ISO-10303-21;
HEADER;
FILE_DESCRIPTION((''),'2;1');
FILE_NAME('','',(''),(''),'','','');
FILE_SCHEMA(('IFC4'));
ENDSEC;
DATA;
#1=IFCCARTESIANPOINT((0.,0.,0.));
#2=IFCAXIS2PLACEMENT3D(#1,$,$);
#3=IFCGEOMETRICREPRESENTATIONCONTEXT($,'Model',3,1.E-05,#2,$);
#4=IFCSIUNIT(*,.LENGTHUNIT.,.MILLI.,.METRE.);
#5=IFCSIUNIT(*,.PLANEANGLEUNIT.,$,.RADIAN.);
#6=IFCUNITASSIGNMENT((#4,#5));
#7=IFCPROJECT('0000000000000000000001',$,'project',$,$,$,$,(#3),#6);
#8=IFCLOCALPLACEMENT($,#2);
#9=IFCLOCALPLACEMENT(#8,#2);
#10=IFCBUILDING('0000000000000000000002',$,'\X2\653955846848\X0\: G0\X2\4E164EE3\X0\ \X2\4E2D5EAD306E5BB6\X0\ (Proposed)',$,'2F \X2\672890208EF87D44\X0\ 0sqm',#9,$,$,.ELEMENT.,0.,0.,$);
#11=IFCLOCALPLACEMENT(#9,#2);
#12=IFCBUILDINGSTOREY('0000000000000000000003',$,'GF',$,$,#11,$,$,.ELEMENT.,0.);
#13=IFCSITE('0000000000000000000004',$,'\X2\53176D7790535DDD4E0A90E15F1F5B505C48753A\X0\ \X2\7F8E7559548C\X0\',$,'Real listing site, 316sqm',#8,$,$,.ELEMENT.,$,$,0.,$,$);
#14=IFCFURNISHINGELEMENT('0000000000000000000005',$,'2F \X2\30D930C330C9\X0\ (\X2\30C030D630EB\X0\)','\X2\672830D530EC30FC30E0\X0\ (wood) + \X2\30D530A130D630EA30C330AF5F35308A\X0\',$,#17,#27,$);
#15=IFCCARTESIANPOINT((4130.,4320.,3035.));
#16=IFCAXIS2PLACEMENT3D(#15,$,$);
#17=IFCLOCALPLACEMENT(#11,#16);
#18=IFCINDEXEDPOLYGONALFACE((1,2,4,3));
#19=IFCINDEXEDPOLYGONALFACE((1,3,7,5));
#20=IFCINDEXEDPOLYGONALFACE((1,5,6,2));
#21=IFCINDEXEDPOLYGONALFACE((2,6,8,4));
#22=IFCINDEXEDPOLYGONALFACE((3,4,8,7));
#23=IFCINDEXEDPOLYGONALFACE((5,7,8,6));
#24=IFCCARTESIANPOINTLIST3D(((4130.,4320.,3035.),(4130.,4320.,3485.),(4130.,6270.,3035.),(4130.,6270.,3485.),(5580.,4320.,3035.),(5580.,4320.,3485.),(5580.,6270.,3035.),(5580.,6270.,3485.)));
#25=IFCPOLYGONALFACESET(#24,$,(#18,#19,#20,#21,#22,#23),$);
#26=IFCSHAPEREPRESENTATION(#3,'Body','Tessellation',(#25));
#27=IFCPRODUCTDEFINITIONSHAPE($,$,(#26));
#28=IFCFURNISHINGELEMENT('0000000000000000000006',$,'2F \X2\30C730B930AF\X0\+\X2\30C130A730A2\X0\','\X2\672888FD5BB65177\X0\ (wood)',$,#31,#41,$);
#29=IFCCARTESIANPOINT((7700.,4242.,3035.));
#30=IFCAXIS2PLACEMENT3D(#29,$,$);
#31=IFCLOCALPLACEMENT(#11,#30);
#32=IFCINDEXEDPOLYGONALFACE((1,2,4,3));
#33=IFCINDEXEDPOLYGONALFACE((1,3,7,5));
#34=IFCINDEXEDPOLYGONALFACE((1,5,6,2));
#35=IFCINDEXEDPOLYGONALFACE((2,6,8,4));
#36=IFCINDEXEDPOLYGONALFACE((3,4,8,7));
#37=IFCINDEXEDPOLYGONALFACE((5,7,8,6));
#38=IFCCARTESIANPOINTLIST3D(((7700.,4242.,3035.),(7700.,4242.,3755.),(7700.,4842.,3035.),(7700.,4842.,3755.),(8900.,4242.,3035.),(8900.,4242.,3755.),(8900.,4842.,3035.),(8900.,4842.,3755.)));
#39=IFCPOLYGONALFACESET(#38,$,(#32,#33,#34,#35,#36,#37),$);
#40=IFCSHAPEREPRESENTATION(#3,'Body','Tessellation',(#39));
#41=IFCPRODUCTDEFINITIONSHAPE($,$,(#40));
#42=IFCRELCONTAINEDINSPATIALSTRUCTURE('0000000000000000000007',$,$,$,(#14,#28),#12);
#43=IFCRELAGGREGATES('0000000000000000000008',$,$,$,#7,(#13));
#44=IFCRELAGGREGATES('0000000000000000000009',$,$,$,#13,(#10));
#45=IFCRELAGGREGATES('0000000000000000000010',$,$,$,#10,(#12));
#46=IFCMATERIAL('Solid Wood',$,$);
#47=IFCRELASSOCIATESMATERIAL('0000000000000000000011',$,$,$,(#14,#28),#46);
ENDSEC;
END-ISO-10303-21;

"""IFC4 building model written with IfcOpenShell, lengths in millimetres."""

from ifc_helpers import new_model, si_unit, frame, frame_2d, origin, place, context, project, spatial, rectangle, extrude, material, element, save


model = new_model("IFC4")

# Units and contexts
model_context = context("Model", 3, precision=1e-05, world=origin())
ifc_project = project(units=[si_unit("LENGTHUNIT", "METRE", prefix="MILLI"), si_unit("PLANEANGLEUNIT", "RADIAN")], contexts=[model_context])

# Site, building, storey
site_placement = place(None, origin())
site = spatial("IfcSite", under=ifc_project, at=site_placement, Name="北海道川上郡弟子屈町 美留和", ObjectType="Real listing site, 316sqm", CompositionType="ELEMENT", RefElevation=0.0)
building_placement = place(site_placement, origin())
building = spatial("IfcBuilding", under=site, at=building_placement, Name="改善案: G0世代 中庭の家 (Proposed)", ObjectType="2F 木造軸組 0sqm", CompositionType="ELEMENT", ElevationOfRefHeight=0.0, ElevationOfTerrain=0.0)
storey_placement = place(building_placement, origin())
storey = spatial("IfcBuildingStorey", under=building, at=storey_placement, Name="GF", CompositionType="ELEMENT", Elevation=0.0)

# Shared definitions
ifc_material_1 = material(Name="Solid Wood")

# Furnishing elements
furnishing_1_placement = place(storey_placement, frame((4130.0, 4320.0, 3035.0)))
element("IfcFurnishingElement", 1, at=furnishing_1_placement, inside=storey, material=ifc_material_1, Name="2F ベッド (ダブル)", Description="木フレーム (wood) + ファブリック張り", context=model_context, shape_type="SweptSolid", body=[
    extrude(rectangle(XDim=1450.0, YDim=1950.0, at=frame_2d((725.0, 975.0))), frame((4130.0, 4320.0, 3035.0)), (0.0, 0.0, 1.0), 450.0),
])
furnishing_2_placement = place(storey_placement, frame((7700.0, 4242.0, 3035.0)))
element("IfcFurnishingElement", 2, at=furnishing_2_placement, inside=storey, material=ifc_material_1, Name="2F デスク+チェア", Description="木製家具 (wood)", context=model_context, shape_type="SweptSolid", body=[
    extrude(rectangle(XDim=1200.0, YDim=600.0, at=frame_2d((600.0, 300.0))), frame((7700.0, 4242.0, 3035.0)), (0.0, 0.0, 1.0), 720.0),
])

save(model, "model.ifc")
